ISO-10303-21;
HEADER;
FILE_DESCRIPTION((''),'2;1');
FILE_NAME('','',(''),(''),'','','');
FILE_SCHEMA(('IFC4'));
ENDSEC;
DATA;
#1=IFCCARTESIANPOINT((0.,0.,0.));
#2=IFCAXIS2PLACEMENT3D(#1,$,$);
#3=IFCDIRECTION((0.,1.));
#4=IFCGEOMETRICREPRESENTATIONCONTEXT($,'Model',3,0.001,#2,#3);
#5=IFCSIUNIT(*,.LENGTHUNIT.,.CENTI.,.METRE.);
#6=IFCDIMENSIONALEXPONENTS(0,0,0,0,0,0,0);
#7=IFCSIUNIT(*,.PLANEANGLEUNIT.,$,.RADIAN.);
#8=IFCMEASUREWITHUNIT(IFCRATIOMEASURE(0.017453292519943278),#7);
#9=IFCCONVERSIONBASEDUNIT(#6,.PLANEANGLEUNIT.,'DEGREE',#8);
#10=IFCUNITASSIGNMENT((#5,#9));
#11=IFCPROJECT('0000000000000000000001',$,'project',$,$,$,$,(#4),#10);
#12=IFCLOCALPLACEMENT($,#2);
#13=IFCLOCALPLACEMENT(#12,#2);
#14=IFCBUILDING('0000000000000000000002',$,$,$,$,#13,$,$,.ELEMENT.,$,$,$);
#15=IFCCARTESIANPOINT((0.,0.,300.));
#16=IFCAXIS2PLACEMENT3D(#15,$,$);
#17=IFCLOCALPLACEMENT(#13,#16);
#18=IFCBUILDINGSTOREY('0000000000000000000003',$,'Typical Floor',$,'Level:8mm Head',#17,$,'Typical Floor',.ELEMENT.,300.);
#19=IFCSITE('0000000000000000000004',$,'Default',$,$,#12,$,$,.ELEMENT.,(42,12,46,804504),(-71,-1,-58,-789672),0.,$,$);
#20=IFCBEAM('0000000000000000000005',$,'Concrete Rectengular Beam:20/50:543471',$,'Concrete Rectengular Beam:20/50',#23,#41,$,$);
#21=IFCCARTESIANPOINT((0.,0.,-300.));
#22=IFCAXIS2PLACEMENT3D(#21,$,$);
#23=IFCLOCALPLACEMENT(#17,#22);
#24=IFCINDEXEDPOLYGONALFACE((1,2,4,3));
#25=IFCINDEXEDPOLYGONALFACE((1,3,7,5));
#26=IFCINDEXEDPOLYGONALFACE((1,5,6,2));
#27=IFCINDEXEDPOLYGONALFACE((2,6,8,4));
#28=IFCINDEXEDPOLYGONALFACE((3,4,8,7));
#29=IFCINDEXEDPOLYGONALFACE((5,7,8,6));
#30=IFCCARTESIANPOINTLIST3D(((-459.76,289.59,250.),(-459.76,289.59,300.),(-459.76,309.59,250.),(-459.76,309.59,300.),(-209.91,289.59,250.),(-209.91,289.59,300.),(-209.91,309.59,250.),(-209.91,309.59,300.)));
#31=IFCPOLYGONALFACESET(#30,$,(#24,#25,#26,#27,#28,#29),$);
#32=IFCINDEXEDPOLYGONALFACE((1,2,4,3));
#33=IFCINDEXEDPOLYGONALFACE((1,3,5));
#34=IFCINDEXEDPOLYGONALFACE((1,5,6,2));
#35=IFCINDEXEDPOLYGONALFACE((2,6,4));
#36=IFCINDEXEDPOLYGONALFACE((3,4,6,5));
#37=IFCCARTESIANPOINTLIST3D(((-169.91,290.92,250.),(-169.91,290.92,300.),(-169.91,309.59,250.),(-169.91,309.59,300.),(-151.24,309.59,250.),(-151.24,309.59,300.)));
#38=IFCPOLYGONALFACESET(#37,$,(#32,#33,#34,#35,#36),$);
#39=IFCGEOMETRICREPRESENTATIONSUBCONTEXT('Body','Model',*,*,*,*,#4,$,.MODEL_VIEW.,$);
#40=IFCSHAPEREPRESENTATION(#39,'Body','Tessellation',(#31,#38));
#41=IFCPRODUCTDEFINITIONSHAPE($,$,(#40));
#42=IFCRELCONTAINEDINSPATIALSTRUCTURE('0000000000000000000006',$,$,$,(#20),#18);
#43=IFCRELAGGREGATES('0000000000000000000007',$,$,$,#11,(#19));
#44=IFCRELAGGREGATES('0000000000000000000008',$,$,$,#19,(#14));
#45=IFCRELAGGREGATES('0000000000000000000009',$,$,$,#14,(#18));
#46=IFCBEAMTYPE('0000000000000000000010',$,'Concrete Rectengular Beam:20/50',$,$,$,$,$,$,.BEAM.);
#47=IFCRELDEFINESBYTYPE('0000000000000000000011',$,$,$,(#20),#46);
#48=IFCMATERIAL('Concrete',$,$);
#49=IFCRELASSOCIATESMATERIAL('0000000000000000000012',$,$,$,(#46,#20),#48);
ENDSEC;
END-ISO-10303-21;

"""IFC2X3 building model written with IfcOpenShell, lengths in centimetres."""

from ifc_helpers import new_model, entity, si_unit, converted_unit, direction, frame, frame_2d, origin, place, context, subcontext, project, spatial, rectangle, extrude, clip, halfspace, source, transform, mapped, material, type_object, type_shapes, element, save


model = new_model("IFC2X3")

# Units and contexts
model_context = context("Model", 3, precision=0.001, world=origin(), true_north=direction((0.0, 1.0)))
body_context = subcontext(model_context, "Body", "Model", "MODEL_VIEW")
ifc_project = project(units=[si_unit("LENGTHUNIT", "METRE", prefix="CENTI"), converted_unit("PLANEANGLEUNIT", "DEGREE", entity("IfcRatioMeasure", 0.017453292519943278), si_unit("PLANEANGLEUNIT", "RADIAN"), dimensions=[0, 0, 0, 0, 0, 0, 0])], contexts=[model_context])

# Site, building, storey
site_placement = place(None, origin())
site = spatial("IfcSite", under=ifc_project, at=site_placement, Name="Default", CompositionType="ELEMENT", RefLatitude=(42, 12, 46, 804504), RefLongitude=(-71, -1, -58, -789672), RefElevation=0.0)
building_placement = place(site_placement, origin())
building = spatial("IfcBuilding", under=site, at=building_placement, CompositionType="ELEMENT")
storey_placement = place(building_placement, frame((0.0, 0.0, 300.0)))
storey = spatial("IfcBuildingStorey", under=building, at=storey_placement, Name="Typical Floor", ObjectType="Level:8mm Head", LongName="Typical Floor", CompositionType="ELEMENT", Elevation=300.0)

# Beam
ifc_material = material(Name="Concrete")
beam_type_1 = type_object("IfcBeamType", Name="Concrete Rectengular Beam:20/50", PredefinedType="BEAM", material=ifc_material)
shared_shape_1 = source(origin(), body_context, "Body", "SweptSolid", [
    extrude(rectangle(XDim=50.0, YDim=20.0, at=frame_2d((0.0, 0.0), x_axis=(1.0, 0.0))), frame((-459.76, 299.59, 275.0), z_axis=(1.0, 0.0, 0.0), x_axis=(0.0, 0.0, -1.0)), (0.0, 0.0, 1.0), 249.85),
    clip(extrude(rectangle(XDim=50.0, YDim=18.68, at=frame_2d((0.0, 0.0), x_axis=(0.0, 1.0))), frame((-169.91, 300.25, 275.0), z_axis=(1.0, 0.0, 0.0), x_axis=(0.0, 1.0, 0.0)), (0.0, 0.0, 1.0), 18.68), halfspace(frame((-194.16, 266.67, 250.0), z_axis=(0.707107, -0.707107, 0.0), x_axis=(0.707107, 0.707107, 0.0)), False)),
])
type_shapes(beam_type_1, [shared_shape_1])
beam_1_placement = place(storey_placement, frame((0.0, 0.0, -300.0)))
element("IfcBeam", 1, at=beam_1_placement, inside=storey, type_object=beam_type_1, material=ifc_material, Name="Concrete Rectengular Beam:20/50:543471", ObjectType="Concrete Rectengular Beam:20/50", context=body_context, shape_type="MappedRepresentation", body=[
    mapped(shared_shape_1, transform((0.0, 0.0, 0.0), scale=1.0)),
])

save(model, "model.ifc")
